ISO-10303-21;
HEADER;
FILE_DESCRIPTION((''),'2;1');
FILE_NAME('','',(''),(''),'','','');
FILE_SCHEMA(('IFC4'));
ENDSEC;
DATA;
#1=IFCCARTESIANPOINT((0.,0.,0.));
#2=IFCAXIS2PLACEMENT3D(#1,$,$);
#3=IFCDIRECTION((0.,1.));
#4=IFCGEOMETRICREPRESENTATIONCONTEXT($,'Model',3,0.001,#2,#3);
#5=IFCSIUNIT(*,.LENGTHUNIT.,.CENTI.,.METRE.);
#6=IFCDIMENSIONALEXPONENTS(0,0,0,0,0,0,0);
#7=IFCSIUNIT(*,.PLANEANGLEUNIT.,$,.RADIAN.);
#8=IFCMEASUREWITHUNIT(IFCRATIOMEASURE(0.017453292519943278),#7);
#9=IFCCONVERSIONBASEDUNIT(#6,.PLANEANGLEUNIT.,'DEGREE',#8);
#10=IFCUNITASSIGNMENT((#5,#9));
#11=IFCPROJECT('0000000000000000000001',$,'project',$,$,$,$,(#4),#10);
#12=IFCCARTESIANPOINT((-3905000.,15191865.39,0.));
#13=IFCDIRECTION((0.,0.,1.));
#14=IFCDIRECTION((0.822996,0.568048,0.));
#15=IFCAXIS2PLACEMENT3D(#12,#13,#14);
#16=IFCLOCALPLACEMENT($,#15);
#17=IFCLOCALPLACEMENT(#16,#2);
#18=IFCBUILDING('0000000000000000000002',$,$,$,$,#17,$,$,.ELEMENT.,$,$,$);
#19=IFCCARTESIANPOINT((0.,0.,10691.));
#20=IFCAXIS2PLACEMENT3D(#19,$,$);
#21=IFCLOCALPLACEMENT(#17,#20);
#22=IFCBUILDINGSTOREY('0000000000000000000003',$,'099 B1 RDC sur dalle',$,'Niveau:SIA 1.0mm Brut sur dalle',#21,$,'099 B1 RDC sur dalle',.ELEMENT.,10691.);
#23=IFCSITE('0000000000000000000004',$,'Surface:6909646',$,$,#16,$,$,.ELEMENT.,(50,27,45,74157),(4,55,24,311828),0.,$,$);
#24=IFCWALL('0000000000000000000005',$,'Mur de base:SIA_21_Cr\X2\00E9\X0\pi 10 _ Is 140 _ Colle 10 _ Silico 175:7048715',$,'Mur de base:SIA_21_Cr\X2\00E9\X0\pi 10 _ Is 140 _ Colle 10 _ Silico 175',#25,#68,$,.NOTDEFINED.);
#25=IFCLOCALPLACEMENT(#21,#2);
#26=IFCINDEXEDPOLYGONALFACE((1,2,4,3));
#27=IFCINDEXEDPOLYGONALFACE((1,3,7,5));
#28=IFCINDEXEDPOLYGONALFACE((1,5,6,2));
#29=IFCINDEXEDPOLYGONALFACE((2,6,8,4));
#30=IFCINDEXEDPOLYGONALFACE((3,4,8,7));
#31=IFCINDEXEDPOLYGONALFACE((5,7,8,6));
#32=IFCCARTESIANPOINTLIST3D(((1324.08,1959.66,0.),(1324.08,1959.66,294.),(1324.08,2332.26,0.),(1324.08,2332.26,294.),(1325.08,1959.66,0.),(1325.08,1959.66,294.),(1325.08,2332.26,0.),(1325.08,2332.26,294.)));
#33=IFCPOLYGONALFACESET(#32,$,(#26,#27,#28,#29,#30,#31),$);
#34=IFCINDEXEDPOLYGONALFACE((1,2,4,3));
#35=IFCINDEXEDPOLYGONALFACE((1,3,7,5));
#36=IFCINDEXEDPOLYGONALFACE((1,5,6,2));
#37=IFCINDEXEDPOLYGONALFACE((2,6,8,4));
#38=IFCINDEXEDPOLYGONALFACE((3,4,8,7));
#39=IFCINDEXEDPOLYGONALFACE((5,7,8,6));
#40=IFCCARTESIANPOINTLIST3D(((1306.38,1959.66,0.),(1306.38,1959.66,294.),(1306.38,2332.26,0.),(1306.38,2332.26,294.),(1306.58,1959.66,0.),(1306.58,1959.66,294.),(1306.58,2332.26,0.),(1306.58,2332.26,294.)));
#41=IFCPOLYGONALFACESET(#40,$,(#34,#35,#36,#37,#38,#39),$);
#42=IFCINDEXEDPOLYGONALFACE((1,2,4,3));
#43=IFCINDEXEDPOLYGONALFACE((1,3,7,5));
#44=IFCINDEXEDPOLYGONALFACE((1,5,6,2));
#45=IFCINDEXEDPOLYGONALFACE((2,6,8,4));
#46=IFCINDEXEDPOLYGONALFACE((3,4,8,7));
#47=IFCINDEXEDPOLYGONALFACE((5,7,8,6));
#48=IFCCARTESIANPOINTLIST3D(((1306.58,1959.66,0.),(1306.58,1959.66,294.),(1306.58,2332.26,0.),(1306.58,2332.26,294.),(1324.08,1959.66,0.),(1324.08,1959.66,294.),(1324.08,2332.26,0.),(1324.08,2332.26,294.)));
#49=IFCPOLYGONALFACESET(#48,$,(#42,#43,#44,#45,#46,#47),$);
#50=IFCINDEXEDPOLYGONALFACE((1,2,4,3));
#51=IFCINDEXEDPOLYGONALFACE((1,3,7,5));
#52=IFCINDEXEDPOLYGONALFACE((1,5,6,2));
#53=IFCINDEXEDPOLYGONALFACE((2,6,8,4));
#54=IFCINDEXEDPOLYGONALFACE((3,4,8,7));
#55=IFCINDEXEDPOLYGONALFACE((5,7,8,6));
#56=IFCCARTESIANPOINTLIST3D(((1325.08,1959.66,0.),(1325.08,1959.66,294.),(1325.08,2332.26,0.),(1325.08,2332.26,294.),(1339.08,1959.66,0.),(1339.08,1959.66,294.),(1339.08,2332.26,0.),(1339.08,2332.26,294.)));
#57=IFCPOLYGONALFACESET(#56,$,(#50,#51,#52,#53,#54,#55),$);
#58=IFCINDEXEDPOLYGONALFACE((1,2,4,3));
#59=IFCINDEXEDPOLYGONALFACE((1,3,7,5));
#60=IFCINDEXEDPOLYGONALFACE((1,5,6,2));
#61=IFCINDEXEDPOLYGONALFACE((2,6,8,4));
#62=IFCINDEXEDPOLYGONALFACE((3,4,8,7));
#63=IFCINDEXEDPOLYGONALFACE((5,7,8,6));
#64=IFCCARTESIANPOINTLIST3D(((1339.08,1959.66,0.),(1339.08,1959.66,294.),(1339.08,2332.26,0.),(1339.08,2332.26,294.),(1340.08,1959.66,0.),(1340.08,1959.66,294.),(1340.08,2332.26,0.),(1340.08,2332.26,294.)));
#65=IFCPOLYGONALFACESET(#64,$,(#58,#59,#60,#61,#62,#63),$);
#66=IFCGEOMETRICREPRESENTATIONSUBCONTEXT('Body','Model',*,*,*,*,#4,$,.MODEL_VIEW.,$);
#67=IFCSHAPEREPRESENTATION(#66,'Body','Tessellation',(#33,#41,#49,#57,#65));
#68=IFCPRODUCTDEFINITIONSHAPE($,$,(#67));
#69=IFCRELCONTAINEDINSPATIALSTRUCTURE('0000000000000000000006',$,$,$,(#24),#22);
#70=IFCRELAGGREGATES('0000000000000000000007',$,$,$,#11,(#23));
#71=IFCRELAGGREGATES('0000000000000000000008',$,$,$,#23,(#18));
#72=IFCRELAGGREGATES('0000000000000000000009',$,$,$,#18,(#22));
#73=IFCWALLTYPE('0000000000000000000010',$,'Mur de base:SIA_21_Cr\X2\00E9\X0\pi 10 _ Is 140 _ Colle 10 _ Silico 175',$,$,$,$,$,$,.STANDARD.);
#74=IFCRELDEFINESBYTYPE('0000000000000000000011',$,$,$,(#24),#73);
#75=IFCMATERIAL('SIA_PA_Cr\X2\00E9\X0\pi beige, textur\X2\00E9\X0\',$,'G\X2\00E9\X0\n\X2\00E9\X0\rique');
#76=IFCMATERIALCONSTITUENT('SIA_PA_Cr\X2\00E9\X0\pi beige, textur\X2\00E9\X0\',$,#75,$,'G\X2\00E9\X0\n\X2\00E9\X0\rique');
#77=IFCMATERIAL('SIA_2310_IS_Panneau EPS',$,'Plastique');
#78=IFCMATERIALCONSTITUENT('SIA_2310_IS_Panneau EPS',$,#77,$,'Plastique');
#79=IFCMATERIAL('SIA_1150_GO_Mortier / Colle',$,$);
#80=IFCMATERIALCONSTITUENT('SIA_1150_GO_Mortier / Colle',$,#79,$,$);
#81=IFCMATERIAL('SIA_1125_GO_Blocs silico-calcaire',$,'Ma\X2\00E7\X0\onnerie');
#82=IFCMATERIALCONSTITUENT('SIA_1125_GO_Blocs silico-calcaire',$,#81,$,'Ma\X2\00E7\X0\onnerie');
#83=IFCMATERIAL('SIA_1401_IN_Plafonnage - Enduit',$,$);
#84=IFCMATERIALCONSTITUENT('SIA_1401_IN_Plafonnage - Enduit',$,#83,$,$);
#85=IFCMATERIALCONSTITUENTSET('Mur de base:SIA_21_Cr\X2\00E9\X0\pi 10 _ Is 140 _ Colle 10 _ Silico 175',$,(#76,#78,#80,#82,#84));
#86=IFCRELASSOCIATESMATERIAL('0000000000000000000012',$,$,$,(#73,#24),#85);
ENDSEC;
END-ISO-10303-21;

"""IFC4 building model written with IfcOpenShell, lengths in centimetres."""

from ifc_helpers import new_model, entity, si_unit, converted_unit, direction, frame, origin, place, context, subcontext, project, spatial, indexed_curve, outline, extrude, material, constituent, constituent_set, type_object, element, save


model = new_model("IFC4")

# Units and contexts
model_context = context("Model", 3, precision=0.001, world=origin(), true_north=direction((0.0, 1.0)))
body_context = subcontext(model_context, "Body", "Model", "MODEL_VIEW")
ifc_project = project(units=[si_unit("LENGTHUNIT", "METRE", prefix="CENTI"), converted_unit("PLANEANGLEUNIT", "DEGREE", entity("IfcRatioMeasure", 0.017453292519943278), si_unit("PLANEANGLEUNIT", "RADIAN"), dimensions=[0, 0, 0, 0, 0, 0, 0])], contexts=[model_context])

# Site, building, storey
site_placement = place(None, frame((-3905000.0, 15191865.39, 0.0), z_axis=(0.0, 0.0, 1.0), x_axis=(0.822996, 0.568048, 0.0)))
site = spatial("IfcSite", under=ifc_project, at=site_placement, Name="Surface:6909646", CompositionType="ELEMENT", RefLatitude=(50, 27, 45, 74157), RefLongitude=(4, 55, 24, 311828), RefElevation=0.0)
building_placement = place(site_placement, origin())
building = spatial("IfcBuilding", under=site, at=building_placement, CompositionType="ELEMENT")
storey_placement = place(building_placement, frame((0.0, 0.0, 10691.0)))
storey = spatial("IfcBuildingStorey", under=building, at=storey_placement, Name="099 B1 RDC sur dalle", ObjectType="Niveau:SIA 1.0mm Brut sur dalle", LongName="099 B1 RDC sur dalle", CompositionType="ELEMENT", Elevation=10691.0)

# Wall
ifc_material_1 = material(Name="SIA_PA_Crépi beige, texturé", Category="Générique")
ifc_constituent_1 = constituent(ifc_material_1, Name="SIA_PA_Crépi beige, texturé", Category="Générique")
ifc_material_2 = material(Name="SIA_2310_IS_Panneau EPS", Category="Plastique")
ifc_constituent_2 = constituent(ifc_material_2, Name="SIA_2310_IS_Panneau EPS", Category="Plastique")
ifc_material_3 = material(Name="SIA_1150_GO_Mortier / Colle")
ifc_constituent_3 = constituent(ifc_material_3, Name="SIA_1150_GO_Mortier / Colle")
ifc_material_4 = material(Name="SIA_1125_GO_Blocs silico-calcaire", Category="Maçonnerie")
ifc_constituent_4 = constituent(ifc_material_4, Name="SIA_1125_GO_Blocs silico-calcaire", Category="Maçonnerie")
ifc_material_5 = material(Name="SIA_1401_IN_Plafonnage - Enduit")
ifc_constituent_5 = constituent(ifc_material_5, Name="SIA_1401_IN_Plafonnage - Enduit")
ifc_constituent_set = constituent_set(constituents=[ifc_constituent_1, ifc_constituent_2, ifc_constituent_3, ifc_constituent_4, ifc_constituent_5], Name="Mur de base:SIA_21_Crépi 10 _ Is 140 _ Colle 10 _ Silico 175")
wall_type = type_object("IfcWallType", Name="Mur de base:SIA_21_Crépi 10 _ Is 140 _ Colle 10 _ Silico 175", PredefinedType="STANDARD", material=ifc_constituent_set)
wall_placement = place(storey_placement, frame((1323.23, 2332.26, 0.0), z_axis=(0.0, 0.0, 1.0), x_axis=(0.0, -1.0, 0.0)))
element("IfcWall", 1, at=wall_placement, inside=storey, type_object=wall_type, material=ifc_constituent_set, Name="Mur de base:SIA_21_Crépi 10 _ Is 140 _ Colle 10 _ Silico 175:7048715", ObjectType="Mur de base:SIA_21_Crépi 10 _ Is 140 _ Colle 10 _ Silico 175", PredefinedType="NOTDEFINED", context=body_context, shape_type="SweptSolid", body=[
    extrude(outline(indexed_curve([(-147.0, -186.3), (147.0, -186.3), (147.0, 186.3), (-147.0, 186.3), (-147.0, -186.3)], self_intersect=False)), frame((186.3, 0.85, 147.0), z_axis=(0.0, 1.0, 0.0), x_axis=(0.0, 0.0, 1.0)), (0.0, 0.0, 1.0), 1.0),
    extrude(outline(indexed_curve([(-147.0, -186.3), (147.0, -186.3), (147.0, 186.3), (-147.0, 186.3), (-147.0, -186.3)], self_intersect=False)), frame((186.3, -16.85, 147.0), z_axis=(0.0, 1.0, 0.0), x_axis=(0.0, 0.0, 1.0)), (0.0, 0.0, 1.0), 0.2),
    extrude(outline(indexed_curve([(-147.0, -186.3), (147.0, -186.3), (147.0, 186.3), (-147.0, 186.3), (-147.0, -186.3)], self_intersect=False)), frame((186.3, -16.65, 147.0), z_axis=(0.0, 1.0, 0.0), x_axis=(0.0, 0.0, 1.0)), (0.0, 0.0, 1.0), 17.5),
    extrude(outline(indexed_curve([(-147.0, -186.3), (147.0, -186.3), (147.0, 186.3), (-147.0, 186.3), (-147.0, -186.3)], self_intersect=False)), frame((186.3, 1.85, 147.0), z_axis=(0.0, 1.0, 0.0), x_axis=(0.0, 0.0, 1.0)), (0.0, 0.0, 1.0), 14.0),
    extrude(outline(indexed_curve([(-147.0, -186.3), (147.0, -186.3), (147.0, 186.3), (-147.0, 186.3), (-147.0, -186.3)], self_intersect=False)), frame((186.3, 15.85, 147.0), z_axis=(0.0, 1.0, 0.0), x_axis=(0.0, 0.0, 1.0)), (0.0, 0.0, 1.0), 1.0),
])

save(model, "model.ifc")
